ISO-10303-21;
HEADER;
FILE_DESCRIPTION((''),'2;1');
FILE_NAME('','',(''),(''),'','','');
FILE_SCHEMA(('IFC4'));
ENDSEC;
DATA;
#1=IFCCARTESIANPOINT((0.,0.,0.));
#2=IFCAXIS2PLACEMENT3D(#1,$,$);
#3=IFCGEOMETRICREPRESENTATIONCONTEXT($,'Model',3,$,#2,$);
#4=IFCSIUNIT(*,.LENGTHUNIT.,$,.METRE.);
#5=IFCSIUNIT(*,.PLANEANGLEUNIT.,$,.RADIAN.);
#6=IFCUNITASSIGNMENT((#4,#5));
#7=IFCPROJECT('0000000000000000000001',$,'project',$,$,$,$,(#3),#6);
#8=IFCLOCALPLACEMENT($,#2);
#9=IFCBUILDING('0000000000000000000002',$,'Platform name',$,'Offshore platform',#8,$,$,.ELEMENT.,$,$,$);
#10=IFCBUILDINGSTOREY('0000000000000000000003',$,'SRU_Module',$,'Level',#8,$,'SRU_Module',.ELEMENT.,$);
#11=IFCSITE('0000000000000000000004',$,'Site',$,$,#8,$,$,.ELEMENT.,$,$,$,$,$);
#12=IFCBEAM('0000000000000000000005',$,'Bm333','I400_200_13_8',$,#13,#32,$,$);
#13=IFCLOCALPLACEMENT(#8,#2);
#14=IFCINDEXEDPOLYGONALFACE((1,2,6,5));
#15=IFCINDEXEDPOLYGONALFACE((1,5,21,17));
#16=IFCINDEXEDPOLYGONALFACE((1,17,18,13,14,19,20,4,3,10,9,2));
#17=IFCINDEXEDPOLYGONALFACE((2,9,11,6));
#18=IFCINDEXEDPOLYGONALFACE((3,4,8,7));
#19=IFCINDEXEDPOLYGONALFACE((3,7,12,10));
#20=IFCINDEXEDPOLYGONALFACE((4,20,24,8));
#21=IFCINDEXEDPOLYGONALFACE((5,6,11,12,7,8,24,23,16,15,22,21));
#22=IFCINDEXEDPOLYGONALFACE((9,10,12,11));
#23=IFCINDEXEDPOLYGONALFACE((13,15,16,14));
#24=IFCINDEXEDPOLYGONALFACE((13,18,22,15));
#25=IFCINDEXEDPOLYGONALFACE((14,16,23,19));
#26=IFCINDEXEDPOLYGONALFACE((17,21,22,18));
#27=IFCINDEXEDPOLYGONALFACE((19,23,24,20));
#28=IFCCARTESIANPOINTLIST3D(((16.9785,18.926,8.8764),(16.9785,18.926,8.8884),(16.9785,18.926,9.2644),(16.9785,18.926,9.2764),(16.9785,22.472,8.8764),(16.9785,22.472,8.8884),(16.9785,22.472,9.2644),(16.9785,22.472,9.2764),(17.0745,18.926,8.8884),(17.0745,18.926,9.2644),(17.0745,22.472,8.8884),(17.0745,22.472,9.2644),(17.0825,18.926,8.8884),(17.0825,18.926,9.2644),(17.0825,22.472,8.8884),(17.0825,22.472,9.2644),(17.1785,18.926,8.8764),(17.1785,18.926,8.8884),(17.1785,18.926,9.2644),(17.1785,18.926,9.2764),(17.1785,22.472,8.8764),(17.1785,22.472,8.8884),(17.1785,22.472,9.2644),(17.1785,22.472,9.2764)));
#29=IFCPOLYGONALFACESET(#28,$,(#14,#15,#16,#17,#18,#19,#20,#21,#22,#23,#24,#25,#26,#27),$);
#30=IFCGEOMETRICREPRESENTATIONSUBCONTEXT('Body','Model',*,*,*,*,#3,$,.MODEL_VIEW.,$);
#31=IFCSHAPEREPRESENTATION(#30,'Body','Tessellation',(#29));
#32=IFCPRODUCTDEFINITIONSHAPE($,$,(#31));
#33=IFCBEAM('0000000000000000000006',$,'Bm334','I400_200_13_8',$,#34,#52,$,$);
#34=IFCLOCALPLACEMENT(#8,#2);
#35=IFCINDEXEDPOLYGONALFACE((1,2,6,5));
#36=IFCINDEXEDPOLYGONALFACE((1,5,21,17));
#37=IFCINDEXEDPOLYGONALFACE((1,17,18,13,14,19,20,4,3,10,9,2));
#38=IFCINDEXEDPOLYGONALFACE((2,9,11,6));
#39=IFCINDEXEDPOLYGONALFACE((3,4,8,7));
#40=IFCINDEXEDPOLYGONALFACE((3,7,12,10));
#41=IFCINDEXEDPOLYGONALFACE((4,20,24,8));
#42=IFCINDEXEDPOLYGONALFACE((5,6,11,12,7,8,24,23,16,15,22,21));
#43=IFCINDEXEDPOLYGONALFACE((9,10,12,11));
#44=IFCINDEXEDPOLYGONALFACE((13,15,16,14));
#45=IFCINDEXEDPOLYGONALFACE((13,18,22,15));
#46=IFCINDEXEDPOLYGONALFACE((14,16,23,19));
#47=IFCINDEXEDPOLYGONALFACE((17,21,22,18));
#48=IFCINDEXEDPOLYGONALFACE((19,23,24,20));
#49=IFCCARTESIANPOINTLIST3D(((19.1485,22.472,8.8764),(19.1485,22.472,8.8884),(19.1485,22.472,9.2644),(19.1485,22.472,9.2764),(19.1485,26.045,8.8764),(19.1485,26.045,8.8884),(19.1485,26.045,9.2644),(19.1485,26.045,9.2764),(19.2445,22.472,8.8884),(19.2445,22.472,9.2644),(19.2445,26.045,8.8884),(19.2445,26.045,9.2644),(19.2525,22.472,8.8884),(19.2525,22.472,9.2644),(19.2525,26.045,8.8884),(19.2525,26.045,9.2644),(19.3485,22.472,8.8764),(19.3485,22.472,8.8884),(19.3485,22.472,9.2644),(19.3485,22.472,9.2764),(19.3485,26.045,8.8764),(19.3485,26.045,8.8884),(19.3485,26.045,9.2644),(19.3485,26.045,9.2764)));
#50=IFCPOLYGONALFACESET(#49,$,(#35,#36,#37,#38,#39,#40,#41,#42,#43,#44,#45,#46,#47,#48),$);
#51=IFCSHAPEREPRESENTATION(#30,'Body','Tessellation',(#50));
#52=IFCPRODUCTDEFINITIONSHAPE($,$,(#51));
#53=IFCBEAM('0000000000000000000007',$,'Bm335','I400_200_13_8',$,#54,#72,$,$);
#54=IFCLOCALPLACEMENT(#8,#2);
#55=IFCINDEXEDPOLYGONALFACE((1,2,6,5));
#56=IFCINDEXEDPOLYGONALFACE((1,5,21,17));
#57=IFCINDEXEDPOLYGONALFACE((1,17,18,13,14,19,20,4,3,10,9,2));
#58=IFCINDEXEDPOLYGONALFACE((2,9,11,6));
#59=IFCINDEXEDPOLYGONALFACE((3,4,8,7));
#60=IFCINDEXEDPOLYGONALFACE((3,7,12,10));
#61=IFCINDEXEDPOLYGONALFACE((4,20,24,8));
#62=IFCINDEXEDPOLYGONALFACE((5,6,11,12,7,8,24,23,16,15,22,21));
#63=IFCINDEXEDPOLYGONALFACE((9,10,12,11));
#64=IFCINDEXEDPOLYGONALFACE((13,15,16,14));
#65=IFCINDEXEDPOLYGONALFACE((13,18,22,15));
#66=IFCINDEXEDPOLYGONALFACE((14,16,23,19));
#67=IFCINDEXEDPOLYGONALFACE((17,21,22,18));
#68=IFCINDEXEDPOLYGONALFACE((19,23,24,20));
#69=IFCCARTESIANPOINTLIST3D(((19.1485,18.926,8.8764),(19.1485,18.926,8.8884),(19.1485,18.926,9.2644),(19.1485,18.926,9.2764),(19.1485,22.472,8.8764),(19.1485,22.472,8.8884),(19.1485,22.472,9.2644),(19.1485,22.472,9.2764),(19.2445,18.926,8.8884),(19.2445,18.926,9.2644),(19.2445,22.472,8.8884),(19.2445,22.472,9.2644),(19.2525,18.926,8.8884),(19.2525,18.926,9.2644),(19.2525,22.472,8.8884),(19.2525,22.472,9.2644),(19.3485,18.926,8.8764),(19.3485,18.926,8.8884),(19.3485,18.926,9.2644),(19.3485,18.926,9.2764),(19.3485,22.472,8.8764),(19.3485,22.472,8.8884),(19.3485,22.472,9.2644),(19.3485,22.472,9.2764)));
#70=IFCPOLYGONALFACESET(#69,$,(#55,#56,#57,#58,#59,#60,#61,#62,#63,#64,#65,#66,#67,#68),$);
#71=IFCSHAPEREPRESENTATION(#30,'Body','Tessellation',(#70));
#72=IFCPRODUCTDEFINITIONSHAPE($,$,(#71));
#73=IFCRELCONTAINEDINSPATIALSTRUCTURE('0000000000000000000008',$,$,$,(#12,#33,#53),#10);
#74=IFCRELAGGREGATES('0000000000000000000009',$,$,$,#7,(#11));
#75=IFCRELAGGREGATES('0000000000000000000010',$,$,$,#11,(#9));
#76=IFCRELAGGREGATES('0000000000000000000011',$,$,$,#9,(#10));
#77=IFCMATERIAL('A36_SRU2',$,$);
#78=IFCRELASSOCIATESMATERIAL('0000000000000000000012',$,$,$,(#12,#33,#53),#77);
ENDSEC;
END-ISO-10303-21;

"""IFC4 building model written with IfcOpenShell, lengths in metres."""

from ifc_helpers import new_model, si_unit, frame, origin, origin_2d, place, context, subcontext, project, spatial, i_section, extrude, source, transform, mapped, material, element, save


model = new_model("IFC4")

# Units and contexts
model_context = context("Model", 3, world=origin())
body_context = subcontext(model_context, "Body", "Model", "MODEL_VIEW")
ifc_project = project(units=[si_unit("LENGTHUNIT", "METRE"), si_unit("PLANEANGLEUNIT", "RADIAN")], contexts=[model_context])

# Site, building, storey
placement_1 = place(None, origin())
site = spatial("IfcSite", under=ifc_project, at=placement_1, Name="Site", CompositionType="ELEMENT")
building = spatial("IfcBuilding", under=site, at=placement_1, Name="Platform name", ObjectType="Offshore platform", CompositionType="ELEMENT")
storey = spatial("IfcBuildingStorey", under=building, at=placement_1, Name="SRU_Module", ObjectType="Level", LongName="SRU_Module", CompositionType="ELEMENT")

# Beams
ifc_material_1 = material(Name="A36_SRU2")
shared_shape_1 = source(origin(), body_context, "Body", "SweptSolid", [
    extrude(i_section(OverallWidth=0.2, OverallDepth=0.4, WebThickness=0.008, FlangeThickness=0.012, FilletRadius=0.0, at=origin_2d()), frame((0.0, 0.0, 0.0), z_axis=(0.0, 1.0, 0.0), x_axis=(-1.0, 0.0, 0.0)), (0.0, 0.0, 1.0), 3.546),
])
placement_2 = place(None, origin())
placement_3 = place(placement_2, origin())
placement_4 = place(placement_3, origin())
beam_1_placement = place(placement_4, frame((17.0785, 18.926, 9.0764)))
element("IfcBeam", 1, at=beam_1_placement, inside=storey, material=ifc_material_1, Name="Bm333", Description="I400_200_13_8", context=body_context, shape_type="MappedRepresentation", body=[
    mapped(shared_shape_1, transform((0.0, 0.0, 0.0), scale=1.0)),
])
shared_shape_2 = source(origin(), body_context, "Body", "SweptSolid", [
    extrude(i_section(OverallWidth=0.2, OverallDepth=0.4, WebThickness=0.008, FlangeThickness=0.012, FilletRadius=0.0, at=origin_2d()), frame((0.0, 0.0, 0.0), z_axis=(0.0, 1.0, 0.0), x_axis=(-1.0, 0.0, 0.0)), (0.0, 0.0, 1.0), 3.573),
])
placement_5 = place(None, origin())
placement_6 = place(placement_5, origin())
placement_7 = place(placement_6, origin())
beam_2_placement = place(placement_7, frame((19.2485, 22.472, 9.0764)))
element("IfcBeam", 2, at=beam_2_placement, inside=storey, material=ifc_material_1, Name="Bm334", Description="I400_200_13_8", context=body_context, shape_type="MappedRepresentation", body=[
    mapped(shared_shape_2, transform((0.0, 0.0, 0.0), scale=1.0)),
])
shared_shape_3 = source(origin(), body_context, "Body", "SweptSolid", [
    extrude(i_section(OverallWidth=0.2, OverallDepth=0.4, WebThickness=0.008, FlangeThickness=0.012, FilletRadius=0.0, at=origin_2d()), frame((0.0, 0.0, 0.0), z_axis=(0.0, 1.0, 0.0), x_axis=(-1.0, 0.0, 0.0)), (0.0, 0.0, 1.0), 3.546),
])
placement_8 = place(None, origin())
placement_9 = place(placement_8, origin())
placement_10 = place(placement_9, origin())
beam_3_placement = place(placement_10, frame((19.2485, 18.926, 9.0764)))
element("IfcBeam", 3, at=beam_3_placement, inside=storey, material=ifc_material_1, Name="Bm335", Description="I400_200_13_8", context=body_context, shape_type="MappedRepresentation", body=[
    mapped(shared_shape_3, transform((0.0, 0.0, 0.0), scale=1.0)),
])

save(model, "model.ifc")
